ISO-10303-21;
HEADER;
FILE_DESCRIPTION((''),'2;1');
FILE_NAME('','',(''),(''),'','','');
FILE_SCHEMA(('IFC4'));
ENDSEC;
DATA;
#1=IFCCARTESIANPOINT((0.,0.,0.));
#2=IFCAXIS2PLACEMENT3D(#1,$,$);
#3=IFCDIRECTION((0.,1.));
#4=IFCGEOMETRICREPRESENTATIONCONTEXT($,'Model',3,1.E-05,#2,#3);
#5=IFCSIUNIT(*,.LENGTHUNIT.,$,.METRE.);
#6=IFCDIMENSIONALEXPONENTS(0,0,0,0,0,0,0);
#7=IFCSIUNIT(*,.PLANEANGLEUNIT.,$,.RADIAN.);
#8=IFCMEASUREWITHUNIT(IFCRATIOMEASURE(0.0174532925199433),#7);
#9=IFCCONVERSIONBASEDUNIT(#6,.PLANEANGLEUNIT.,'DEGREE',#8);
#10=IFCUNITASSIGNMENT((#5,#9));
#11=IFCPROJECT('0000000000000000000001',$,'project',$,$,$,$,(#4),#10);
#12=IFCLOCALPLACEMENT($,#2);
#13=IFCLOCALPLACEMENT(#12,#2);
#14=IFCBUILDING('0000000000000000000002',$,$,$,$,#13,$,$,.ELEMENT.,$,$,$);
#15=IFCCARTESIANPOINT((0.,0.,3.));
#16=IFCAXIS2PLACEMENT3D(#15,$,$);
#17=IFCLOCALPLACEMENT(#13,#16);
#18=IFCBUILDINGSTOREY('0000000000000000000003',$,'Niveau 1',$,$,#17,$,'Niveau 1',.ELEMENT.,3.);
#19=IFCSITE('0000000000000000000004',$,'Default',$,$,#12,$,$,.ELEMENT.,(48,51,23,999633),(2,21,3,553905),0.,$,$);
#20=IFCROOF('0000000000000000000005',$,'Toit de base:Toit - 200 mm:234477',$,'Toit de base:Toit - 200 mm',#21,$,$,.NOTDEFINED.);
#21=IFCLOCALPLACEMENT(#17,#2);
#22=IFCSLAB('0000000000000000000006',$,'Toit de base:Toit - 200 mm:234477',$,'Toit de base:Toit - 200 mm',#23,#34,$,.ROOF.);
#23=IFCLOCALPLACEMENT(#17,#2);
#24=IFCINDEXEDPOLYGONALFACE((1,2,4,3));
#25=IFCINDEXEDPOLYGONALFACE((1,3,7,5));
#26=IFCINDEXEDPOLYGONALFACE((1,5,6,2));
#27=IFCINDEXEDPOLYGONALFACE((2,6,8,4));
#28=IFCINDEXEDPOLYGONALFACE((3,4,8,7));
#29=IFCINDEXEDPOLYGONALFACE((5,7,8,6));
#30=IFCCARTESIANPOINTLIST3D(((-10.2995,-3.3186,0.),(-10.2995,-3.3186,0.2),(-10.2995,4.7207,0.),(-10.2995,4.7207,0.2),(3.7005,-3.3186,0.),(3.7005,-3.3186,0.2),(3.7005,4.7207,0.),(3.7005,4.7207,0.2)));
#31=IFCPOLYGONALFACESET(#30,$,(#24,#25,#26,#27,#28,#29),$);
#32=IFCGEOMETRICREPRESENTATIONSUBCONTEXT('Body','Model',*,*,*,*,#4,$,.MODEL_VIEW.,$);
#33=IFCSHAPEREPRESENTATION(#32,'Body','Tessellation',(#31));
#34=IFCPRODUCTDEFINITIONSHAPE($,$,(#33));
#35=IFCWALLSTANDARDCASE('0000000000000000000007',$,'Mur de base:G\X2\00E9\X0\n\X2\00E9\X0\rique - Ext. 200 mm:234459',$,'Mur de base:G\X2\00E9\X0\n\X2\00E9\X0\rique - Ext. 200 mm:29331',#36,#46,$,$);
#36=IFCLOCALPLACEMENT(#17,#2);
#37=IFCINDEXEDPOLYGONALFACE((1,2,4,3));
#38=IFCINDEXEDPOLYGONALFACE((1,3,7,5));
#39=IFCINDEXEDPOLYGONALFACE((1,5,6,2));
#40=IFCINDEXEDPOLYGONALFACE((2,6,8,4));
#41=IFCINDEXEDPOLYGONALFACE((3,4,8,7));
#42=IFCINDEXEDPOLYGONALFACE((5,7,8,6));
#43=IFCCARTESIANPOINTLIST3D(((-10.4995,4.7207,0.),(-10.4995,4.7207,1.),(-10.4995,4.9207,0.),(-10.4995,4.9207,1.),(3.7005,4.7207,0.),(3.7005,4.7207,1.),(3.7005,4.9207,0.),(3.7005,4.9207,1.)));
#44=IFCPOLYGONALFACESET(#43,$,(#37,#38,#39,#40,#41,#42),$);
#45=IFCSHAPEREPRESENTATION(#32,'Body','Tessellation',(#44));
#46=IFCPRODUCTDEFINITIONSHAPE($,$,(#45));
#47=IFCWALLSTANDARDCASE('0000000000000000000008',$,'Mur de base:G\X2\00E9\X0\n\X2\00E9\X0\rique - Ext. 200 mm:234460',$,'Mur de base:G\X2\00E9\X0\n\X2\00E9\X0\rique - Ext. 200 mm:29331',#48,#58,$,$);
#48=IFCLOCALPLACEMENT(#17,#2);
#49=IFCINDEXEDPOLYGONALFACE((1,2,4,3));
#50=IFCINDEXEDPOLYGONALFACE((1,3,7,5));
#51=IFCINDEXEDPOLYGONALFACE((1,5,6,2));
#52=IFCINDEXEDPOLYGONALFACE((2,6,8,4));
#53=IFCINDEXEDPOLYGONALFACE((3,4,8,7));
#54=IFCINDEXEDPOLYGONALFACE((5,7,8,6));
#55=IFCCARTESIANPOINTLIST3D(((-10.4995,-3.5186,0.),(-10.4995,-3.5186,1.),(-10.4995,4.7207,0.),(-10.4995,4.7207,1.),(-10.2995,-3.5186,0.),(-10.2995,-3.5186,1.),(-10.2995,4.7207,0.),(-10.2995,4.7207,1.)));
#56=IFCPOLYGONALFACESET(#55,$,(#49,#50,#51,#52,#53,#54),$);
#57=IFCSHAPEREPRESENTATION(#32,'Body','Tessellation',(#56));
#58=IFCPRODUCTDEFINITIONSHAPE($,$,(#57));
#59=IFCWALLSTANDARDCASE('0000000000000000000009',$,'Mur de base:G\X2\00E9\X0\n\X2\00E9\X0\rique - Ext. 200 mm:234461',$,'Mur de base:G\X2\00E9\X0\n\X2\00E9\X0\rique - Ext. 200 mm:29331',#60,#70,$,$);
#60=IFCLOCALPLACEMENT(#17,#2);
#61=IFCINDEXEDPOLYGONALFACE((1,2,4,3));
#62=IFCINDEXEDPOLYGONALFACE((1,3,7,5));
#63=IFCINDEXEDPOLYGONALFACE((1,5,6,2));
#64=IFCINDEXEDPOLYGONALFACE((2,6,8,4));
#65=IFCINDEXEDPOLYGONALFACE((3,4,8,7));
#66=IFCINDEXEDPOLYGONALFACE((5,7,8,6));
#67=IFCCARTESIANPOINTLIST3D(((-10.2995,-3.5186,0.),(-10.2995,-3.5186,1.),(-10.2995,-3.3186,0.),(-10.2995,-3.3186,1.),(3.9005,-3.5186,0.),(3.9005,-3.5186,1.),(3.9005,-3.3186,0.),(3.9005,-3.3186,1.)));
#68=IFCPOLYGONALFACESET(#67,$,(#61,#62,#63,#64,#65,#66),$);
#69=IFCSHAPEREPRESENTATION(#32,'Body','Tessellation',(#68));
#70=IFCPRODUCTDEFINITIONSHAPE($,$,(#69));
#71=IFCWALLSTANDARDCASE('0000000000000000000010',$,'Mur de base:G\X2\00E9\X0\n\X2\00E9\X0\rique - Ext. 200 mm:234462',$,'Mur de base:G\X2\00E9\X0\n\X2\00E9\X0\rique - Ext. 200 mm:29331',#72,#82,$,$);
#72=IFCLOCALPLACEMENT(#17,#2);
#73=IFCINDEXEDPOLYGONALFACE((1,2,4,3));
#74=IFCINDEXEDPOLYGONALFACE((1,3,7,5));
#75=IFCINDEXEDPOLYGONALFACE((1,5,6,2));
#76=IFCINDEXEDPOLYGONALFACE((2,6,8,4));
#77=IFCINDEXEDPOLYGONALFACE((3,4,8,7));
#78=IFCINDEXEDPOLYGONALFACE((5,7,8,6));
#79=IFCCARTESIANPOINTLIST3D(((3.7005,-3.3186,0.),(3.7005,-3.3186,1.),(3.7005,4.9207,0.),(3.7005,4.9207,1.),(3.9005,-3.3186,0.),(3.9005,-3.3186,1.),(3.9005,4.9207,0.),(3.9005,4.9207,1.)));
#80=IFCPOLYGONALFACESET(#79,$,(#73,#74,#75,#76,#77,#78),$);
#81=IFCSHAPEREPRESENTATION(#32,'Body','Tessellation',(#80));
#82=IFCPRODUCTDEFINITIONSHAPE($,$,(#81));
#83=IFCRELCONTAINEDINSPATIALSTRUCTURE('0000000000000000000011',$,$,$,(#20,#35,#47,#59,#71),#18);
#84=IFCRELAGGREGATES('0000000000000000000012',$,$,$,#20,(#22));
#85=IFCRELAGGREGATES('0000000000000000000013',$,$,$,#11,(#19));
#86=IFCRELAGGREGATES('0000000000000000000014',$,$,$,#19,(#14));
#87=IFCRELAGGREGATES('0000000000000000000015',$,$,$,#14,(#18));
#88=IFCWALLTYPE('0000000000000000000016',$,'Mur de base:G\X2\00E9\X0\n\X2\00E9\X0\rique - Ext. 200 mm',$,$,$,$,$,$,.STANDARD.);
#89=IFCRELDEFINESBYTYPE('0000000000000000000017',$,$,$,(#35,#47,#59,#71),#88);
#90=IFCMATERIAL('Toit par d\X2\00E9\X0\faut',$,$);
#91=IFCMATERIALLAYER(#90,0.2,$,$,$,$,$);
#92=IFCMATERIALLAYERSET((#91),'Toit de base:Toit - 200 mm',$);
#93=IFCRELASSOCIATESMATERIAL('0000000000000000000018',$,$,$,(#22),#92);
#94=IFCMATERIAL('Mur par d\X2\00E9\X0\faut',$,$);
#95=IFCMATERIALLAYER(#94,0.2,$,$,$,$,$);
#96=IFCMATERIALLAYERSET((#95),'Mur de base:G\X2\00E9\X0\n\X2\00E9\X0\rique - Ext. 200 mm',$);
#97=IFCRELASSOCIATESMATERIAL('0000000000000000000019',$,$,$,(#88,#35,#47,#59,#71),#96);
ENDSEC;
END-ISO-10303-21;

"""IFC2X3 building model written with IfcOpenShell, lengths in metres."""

from ifc_helpers import new_model, entity, si_unit, converted_unit, direction, frame, frame_2d, origin, origin_2d_with_axis, place, context, subcontext, project, spatial, rectangle, extrude, material, layer, layer_set, layer_usage, type_object, element, aggregate, save


model = new_model("IFC2X3")

# Units and contexts
model_context = context("Model", 3, precision=1e-05, world=origin(), true_north=direction((0.0, 1.0)))
body_context = subcontext(model_context, "Body", "Model", "MODEL_VIEW")
ifc_project = project(units=[si_unit("LENGTHUNIT", "METRE"), converted_unit("PLANEANGLEUNIT", "DEGREE", entity("IfcRatioMeasure", 0.0174532925199433), si_unit("PLANEANGLEUNIT", "RADIAN"), dimensions=[0, 0, 0, 0, 0, 0, 0])], contexts=[model_context])

# Site, building, storey
site_placement = place(None, origin())
site = spatial("IfcSite", under=ifc_project, at=site_placement, Name="Default", CompositionType="ELEMENT", RefLatitude=(48, 51, 23, 999633), RefLongitude=(2, 21, 3, 553905), RefElevation=0.0)
building_placement = place(site_placement, origin())
building = spatial("IfcBuilding", under=site, at=building_placement, CompositionType="ELEMENT")
storey_placement = place(building_placement, frame((0.0, 0.0, 3.0)))
storey = spatial("IfcBuildingStorey", under=building, at=storey_placement, Name="Niveau 1", LongName="Niveau 1", CompositionType="ELEMENT", Elevation=3.0)

# Roof, slab
roof_placement = place(storey_placement, frame((-10.2995, -3.3186, 0.0)))
roof = element("IfcRoof", 1, at=roof_placement, inside=storey, Name="Toit de base:Toit - 200 mm:234477", ObjectType="Toit de base:Toit - 200 mm", ShapeType="NOTDEFINED")
ifc_material_1 = material(Name="Toit par défaut")
ifc_layer_1 = layer(ifc_material_1, 0.2)
ifc_layer_set_1 = layer_set([ifc_layer_1], Name="Toit de base:Toit - 200 mm")
slab_placement = place(roof_placement, origin())
slab = element("IfcSlab", 2, at=slab_placement, material=ifc_layer_set_1, Name="Toit de base:Toit - 200 mm:234477", ObjectType="Toit de base:Toit - 200 mm", PredefinedType="ROOF", context=body_context, shape_type="SweptSolid", body=[
    extrude(rectangle(XDim=14.0, YDim=8.0393, at=origin_2d_with_axis()), frame((7.0, 4.0196, 0.0)), (0.0, 0.0, 1.0), 0.2),
])
aggregate(roof, [slab])

# Walls
ifc_material_2 = material(Name="Mur par défaut")
ifc_layer_2 = layer(ifc_material_2, 0.2)
ifc_layer_set_2 = layer_set([ifc_layer_2], Name="Mur de base:Générique - Ext. 200 mm")
ifc_layer_usage_1 = layer_usage(ifc_layer_set_2, "AXIS2", "NEGATIVE", 0.1)
wall_type = type_object("IfcWallType", Name="Mur de base:Générique - Ext. 200 mm", PredefinedType="STANDARD", material=ifc_layer_set_2)
wall_1_placement = place(storey_placement, frame((-10.4995, 4.8207, 0.0)))
element("IfcWallStandardCase", 3, at=wall_1_placement, inside=storey, type_object=wall_type, material=ifc_layer_usage_1, Name="Mur de base:Générique - Ext. 200 mm:234459", ObjectType="Mur de base:Générique - Ext. 200 mm:29331", context=body_context, shape_type="SweptSolid", body=[
    extrude(rectangle(XDim=14.2, YDim=0.2, at=frame_2d((7.1, 0.0), x_axis=(-1.0, 0.0))), origin(), (0.0, 0.0, 1.0), 1.0),
])
ifc_layer_usage_2 = layer_usage(ifc_layer_set_2, "AXIS2", "NEGATIVE", 0.1)
wall_2_placement = place(storey_placement, frame((-10.3995, -3.5186, 0.0), z_axis=(0.0, 0.0, 1.0), x_axis=(0.0, 1.0, 0.0)))
element("IfcWallStandardCase", 4, at=wall_2_placement, inside=storey, type_object=wall_type, material=ifc_layer_usage_2, Name="Mur de base:Générique - Ext. 200 mm:234460", ObjectType="Mur de base:Générique - Ext. 200 mm:29331", context=body_context, shape_type="SweptSolid", body=[
    extrude(rectangle(XDim=8.2393, YDim=0.2, at=frame_2d((4.1196, 0.0), x_axis=(-1.0, 0.0))), origin(), (0.0, 0.0, 1.0), 1.0),
])
ifc_layer_usage_3 = layer_usage(ifc_layer_set_2, "AXIS2", "NEGATIVE", 0.1)
wall_3_placement = place(storey_placement, frame((3.9005, -3.4186, 0.0), z_axis=(0.0, 0.0, 1.0), x_axis=(-1.0, 0.0, 0.0)))
element("IfcWallStandardCase", 5, at=wall_3_placement, inside=storey, type_object=wall_type, material=ifc_layer_usage_3, Name="Mur de base:Générique - Ext. 200 mm:234461", ObjectType="Mur de base:Générique - Ext. 200 mm:29331", context=body_context, shape_type="SweptSolid", body=[
    extrude(rectangle(XDim=14.2, YDim=0.2, at=frame_2d((7.1, 0.0), x_axis=(-1.0, 0.0))), origin(), (0.0, 0.0, 1.0), 1.0),
])
ifc_layer_usage_4 = layer_usage(ifc_layer_set_2, "AXIS2", "NEGATIVE", 0.1)
wall_4_placement = place(storey_placement, frame((3.8005, 4.9207, 0.0), z_axis=(0.0, 0.0, 1.0), x_axis=(0.0, -1.0, 0.0)))
element("IfcWallStandardCase", 6, at=wall_4_placement, inside=storey, type_object=wall_type, material=ifc_layer_usage_4, Name="Mur de base:Générique - Ext. 200 mm:234462", ObjectType="Mur de base:Générique - Ext. 200 mm:29331", context=body_context, shape_type="SweptSolid", body=[
    extrude(rectangle(XDim=8.2393, YDim=0.2, at=frame_2d((4.1196, 0.0), x_axis=(-1.0, 0.0))), origin(), (0.0, 0.0, 1.0), 1.0),
])

save(model, "model.ifc")
